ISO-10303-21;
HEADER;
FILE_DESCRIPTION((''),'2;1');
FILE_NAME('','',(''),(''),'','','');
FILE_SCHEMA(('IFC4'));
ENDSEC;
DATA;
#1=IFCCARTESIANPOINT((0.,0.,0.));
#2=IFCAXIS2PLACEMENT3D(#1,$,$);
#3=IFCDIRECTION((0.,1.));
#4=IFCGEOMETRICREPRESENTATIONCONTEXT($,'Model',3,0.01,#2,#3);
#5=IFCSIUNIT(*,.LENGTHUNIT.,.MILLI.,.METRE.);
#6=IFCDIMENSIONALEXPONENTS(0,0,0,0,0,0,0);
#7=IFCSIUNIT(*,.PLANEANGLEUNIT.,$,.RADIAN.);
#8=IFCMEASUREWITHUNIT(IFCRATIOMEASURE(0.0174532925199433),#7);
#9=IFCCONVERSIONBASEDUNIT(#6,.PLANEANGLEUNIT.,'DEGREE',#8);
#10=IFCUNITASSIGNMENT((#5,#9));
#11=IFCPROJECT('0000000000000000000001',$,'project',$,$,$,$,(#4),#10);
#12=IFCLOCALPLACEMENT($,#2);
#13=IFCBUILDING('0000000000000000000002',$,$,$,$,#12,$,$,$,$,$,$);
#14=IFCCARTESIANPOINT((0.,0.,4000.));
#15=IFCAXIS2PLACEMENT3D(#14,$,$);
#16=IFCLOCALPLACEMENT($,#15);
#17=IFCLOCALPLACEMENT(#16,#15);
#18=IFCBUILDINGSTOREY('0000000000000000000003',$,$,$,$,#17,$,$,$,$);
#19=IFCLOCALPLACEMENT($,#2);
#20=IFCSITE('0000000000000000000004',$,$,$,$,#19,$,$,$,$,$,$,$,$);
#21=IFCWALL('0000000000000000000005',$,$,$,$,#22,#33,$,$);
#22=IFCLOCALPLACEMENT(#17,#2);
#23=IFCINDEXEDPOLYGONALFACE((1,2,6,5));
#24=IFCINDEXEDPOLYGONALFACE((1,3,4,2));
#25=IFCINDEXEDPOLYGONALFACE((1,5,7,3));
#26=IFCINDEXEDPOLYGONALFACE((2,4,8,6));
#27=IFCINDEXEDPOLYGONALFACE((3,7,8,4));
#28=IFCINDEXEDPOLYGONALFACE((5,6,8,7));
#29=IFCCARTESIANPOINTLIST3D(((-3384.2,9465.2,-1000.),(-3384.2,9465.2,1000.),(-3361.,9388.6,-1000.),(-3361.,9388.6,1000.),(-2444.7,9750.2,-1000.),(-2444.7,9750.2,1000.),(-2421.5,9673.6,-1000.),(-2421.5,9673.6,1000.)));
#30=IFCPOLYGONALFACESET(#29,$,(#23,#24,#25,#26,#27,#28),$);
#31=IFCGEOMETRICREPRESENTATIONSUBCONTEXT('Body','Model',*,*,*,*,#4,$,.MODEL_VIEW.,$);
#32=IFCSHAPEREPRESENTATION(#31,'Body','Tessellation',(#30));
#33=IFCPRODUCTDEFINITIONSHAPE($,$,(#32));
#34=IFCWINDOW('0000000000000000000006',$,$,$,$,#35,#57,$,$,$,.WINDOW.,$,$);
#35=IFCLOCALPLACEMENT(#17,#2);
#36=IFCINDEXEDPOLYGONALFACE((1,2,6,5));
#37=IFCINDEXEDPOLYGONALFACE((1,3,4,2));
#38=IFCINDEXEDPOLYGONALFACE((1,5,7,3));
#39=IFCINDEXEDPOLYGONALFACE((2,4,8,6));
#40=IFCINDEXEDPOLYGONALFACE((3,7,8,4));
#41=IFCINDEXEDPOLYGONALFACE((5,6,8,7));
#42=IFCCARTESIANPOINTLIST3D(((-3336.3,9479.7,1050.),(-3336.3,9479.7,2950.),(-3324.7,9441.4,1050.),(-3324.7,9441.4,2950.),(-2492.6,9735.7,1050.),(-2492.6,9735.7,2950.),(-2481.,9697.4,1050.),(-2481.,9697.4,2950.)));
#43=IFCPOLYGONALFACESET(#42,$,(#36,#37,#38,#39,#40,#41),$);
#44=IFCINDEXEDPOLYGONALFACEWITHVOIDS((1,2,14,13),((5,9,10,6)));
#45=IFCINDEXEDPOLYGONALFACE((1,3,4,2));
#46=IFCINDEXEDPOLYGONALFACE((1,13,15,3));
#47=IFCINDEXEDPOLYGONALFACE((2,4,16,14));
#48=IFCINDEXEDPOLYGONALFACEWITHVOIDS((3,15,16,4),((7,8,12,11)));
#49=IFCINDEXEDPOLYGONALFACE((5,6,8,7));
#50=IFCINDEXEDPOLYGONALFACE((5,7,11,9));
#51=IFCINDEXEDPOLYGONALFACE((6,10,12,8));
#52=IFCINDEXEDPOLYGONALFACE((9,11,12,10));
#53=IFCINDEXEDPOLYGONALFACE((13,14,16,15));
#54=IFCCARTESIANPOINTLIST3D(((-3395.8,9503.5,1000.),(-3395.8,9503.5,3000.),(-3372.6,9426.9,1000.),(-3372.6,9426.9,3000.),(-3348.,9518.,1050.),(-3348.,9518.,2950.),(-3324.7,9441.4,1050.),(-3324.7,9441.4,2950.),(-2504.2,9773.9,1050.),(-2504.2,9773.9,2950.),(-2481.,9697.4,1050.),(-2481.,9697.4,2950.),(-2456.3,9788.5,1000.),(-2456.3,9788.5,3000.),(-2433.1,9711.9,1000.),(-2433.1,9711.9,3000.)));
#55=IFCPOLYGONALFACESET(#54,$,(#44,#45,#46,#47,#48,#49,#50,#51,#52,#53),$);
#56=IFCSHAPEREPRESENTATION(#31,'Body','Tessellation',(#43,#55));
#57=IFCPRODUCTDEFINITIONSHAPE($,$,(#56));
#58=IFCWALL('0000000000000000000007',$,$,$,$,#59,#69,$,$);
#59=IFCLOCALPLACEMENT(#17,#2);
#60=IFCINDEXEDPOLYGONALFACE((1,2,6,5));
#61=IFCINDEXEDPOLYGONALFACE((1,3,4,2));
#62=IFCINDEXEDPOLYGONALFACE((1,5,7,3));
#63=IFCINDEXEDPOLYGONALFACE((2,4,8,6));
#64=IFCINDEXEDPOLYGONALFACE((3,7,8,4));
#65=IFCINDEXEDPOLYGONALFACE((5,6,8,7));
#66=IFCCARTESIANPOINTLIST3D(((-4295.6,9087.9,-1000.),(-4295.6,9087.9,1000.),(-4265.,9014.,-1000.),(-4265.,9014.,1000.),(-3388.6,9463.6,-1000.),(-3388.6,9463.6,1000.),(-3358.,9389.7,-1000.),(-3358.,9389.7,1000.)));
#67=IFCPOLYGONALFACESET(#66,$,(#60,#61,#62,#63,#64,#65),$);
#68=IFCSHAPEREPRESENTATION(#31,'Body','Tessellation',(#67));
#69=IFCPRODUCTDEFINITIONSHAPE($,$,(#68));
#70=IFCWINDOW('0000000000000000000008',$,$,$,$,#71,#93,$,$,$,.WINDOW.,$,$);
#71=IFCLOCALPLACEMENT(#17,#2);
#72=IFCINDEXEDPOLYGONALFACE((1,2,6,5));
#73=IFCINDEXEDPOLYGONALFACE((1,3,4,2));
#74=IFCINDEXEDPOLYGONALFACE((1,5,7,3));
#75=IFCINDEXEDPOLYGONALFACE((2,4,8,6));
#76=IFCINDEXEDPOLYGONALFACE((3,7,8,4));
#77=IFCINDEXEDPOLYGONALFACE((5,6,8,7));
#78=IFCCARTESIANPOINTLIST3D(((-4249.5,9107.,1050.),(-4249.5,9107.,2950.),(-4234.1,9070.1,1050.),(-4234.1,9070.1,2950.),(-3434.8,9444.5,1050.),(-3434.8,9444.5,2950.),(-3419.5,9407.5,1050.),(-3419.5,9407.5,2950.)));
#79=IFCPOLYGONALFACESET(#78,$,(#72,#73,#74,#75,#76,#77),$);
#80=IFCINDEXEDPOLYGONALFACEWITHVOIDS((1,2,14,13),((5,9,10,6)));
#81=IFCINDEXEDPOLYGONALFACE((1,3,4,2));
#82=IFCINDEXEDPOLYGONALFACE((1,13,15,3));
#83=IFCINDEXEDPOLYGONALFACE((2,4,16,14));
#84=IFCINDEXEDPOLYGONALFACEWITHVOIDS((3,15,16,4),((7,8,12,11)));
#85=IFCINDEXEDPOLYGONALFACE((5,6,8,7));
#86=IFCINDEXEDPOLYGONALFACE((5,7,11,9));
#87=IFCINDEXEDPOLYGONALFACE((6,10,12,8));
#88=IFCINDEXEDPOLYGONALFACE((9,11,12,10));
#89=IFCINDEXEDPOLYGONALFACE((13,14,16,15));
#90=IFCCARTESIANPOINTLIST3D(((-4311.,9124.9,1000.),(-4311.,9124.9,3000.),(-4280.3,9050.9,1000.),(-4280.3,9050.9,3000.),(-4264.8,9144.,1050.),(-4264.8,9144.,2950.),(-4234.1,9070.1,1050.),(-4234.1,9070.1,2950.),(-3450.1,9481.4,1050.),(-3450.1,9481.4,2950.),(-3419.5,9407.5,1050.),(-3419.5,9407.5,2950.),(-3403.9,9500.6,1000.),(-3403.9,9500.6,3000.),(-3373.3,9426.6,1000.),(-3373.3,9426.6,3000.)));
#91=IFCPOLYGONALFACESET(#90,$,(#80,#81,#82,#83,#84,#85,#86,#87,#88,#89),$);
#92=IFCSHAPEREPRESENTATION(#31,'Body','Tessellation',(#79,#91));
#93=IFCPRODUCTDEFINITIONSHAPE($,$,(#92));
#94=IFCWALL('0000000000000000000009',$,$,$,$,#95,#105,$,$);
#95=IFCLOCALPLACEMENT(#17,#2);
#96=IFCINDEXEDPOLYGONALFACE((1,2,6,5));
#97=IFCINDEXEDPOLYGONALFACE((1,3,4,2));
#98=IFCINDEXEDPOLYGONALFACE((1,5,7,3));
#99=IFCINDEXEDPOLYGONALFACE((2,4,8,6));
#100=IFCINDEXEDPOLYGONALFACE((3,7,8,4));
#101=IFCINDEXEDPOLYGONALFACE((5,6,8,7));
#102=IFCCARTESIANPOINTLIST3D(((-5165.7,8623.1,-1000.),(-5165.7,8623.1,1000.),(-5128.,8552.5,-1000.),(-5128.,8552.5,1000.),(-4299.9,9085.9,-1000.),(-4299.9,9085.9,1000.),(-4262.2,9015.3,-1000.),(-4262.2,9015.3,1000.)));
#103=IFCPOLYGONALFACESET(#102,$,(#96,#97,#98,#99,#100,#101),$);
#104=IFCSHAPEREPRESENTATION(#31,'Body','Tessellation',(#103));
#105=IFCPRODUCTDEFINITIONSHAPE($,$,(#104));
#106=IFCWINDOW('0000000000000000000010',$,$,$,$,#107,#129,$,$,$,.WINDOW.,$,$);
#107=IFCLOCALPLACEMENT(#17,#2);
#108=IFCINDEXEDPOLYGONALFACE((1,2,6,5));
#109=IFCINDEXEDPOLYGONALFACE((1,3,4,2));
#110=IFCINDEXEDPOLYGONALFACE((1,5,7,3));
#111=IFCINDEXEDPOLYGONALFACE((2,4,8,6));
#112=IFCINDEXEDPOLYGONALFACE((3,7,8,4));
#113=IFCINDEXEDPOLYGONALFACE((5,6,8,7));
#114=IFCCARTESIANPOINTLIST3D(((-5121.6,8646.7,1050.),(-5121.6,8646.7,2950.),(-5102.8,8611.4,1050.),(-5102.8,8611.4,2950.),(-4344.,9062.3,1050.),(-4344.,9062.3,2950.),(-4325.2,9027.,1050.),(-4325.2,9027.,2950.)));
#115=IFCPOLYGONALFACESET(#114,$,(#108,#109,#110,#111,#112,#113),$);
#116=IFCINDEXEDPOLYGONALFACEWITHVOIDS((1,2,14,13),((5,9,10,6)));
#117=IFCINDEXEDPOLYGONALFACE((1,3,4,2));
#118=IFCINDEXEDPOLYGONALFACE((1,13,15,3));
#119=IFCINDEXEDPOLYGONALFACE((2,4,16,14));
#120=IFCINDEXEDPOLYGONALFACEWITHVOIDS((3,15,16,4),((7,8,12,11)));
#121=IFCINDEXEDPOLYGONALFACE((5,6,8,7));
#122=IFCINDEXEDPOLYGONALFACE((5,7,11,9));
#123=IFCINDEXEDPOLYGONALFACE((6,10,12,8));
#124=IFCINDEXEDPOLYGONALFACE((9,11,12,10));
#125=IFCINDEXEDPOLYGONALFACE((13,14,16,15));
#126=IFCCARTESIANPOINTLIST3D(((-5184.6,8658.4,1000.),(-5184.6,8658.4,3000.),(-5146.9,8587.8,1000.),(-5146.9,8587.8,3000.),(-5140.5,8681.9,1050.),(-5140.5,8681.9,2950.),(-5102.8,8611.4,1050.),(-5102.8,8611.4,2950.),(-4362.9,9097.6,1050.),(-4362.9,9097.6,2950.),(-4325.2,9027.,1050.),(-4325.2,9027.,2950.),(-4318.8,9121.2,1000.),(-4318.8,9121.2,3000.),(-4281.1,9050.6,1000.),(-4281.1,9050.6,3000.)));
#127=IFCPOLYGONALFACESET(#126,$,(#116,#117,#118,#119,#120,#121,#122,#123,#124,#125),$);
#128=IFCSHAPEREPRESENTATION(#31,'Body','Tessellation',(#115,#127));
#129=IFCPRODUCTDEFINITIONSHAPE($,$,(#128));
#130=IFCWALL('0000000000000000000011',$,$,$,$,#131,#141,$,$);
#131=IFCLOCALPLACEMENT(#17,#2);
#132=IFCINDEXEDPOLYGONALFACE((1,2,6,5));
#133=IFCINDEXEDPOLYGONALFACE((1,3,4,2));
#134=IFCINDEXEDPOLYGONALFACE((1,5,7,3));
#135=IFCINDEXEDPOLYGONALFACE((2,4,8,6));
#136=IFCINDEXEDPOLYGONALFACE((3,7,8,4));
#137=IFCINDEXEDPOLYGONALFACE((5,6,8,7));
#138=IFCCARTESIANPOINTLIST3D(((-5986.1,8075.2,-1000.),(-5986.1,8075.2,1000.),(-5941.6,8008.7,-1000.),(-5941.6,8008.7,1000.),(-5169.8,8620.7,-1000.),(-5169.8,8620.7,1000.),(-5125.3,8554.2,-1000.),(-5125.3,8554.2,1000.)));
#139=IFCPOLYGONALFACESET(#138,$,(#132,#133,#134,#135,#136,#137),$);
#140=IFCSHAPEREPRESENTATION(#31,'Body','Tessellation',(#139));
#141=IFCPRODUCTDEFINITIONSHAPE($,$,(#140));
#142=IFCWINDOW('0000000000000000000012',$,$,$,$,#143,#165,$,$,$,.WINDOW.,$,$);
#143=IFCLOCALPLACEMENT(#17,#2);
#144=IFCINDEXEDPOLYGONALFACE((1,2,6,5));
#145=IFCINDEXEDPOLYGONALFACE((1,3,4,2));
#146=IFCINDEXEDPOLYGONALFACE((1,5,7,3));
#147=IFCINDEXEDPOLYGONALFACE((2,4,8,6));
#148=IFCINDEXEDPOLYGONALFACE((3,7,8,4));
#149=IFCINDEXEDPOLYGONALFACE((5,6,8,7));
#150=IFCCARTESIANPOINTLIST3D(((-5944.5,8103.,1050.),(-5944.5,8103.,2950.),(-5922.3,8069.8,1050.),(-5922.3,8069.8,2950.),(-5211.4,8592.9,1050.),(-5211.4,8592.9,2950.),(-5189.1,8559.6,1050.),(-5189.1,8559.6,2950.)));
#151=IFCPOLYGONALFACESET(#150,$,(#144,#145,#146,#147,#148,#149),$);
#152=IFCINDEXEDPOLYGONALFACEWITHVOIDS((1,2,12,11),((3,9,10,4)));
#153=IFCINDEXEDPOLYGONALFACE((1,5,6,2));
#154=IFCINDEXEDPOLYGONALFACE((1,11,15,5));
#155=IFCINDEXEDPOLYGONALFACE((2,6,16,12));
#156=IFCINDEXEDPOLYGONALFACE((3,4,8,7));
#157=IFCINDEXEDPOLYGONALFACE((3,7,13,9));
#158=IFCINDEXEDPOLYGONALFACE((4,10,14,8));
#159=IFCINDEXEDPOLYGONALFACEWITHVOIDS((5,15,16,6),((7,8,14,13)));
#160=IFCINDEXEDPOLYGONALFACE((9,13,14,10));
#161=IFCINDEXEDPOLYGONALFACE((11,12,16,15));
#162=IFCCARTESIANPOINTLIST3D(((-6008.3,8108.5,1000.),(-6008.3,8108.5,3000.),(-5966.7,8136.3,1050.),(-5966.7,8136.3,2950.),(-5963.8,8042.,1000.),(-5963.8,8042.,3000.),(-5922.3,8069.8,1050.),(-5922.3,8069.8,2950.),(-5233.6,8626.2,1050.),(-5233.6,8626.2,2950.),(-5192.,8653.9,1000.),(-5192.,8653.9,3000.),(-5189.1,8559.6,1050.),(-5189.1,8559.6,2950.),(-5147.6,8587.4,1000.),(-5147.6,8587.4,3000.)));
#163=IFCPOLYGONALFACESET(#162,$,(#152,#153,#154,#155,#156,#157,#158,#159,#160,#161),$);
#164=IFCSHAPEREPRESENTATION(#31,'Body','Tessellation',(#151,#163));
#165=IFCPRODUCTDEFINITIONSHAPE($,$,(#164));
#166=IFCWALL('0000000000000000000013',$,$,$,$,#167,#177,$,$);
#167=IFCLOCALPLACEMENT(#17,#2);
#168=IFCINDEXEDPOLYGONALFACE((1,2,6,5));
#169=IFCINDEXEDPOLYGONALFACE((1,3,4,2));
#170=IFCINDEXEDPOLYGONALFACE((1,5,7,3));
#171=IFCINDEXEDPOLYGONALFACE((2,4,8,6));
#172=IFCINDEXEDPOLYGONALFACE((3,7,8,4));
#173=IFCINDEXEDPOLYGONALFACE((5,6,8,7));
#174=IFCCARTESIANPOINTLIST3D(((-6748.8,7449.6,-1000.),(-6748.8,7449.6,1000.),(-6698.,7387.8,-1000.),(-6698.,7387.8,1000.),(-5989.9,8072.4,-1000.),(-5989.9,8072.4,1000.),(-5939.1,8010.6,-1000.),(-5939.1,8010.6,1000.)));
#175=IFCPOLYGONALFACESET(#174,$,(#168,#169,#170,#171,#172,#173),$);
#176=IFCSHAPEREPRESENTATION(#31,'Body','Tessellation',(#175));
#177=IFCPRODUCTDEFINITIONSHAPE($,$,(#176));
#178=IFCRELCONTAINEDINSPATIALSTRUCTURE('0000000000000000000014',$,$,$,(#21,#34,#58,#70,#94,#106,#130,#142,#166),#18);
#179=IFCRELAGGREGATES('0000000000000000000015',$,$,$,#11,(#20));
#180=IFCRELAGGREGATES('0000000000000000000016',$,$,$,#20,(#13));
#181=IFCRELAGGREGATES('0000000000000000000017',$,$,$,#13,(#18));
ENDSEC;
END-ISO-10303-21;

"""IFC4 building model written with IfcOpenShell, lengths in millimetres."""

from ifc_helpers import new_model, entity, si_unit, converted_unit, direction, frame, origin, origin_2d, place, context, subcontext, project, spatial, rectangle, extrude, element, save


model = new_model("IFC4")

# Units and contexts
model_context = context("Model", 3, precision=0.01, world=origin(), true_north=direction((0.0, 1.0)))
body_context = subcontext(model_context, "Body", "Model", "MODEL_VIEW")
ifc_project = project(units=[si_unit("LENGTHUNIT", "METRE", prefix="MILLI"), converted_unit("PLANEANGLEUNIT", "DEGREE", entity("IfcRatioMeasure", 0.0174532925199433), si_unit("PLANEANGLEUNIT", "RADIAN"), dimensions=[0, 0, 0, 0, 0, 0, 0])], contexts=[model_context])

# Site, building, storey
site_placement = place(None, origin())
site = spatial("IfcSite", under=ifc_project, at=site_placement)
building_placement = place(None, origin())
building = spatial("IfcBuilding", under=site, at=building_placement)
placement = place(None, frame((0.0, 0.0, 4000.0)))
storey_placement = place(placement, frame((0.0, 0.0, 4000.0)))
storey = spatial("IfcBuildingStorey", under=building, at=storey_placement)

# Shared definitions
cartesian_point_1 = entity("IfcCartesianPoint", [-440.9, -950.0])
shared_polyline = entity("IfcPolyline", [cartesian_point_1, entity("IfcCartesianPoint", [-440.9, 950.0]), entity("IfcCartesianPoint", [-440.9, 950.0]), entity("IfcCartesianPoint", [440.9, 950.0]), entity("IfcCartesianPoint", [440.9, 950.0]), entity("IfcCartesianPoint", [440.9, -950.0]), entity("IfcCartesianPoint", [440.9, -950.0]), entity("IfcCartesianPoint", [-440.9, -950.0]), cartesian_point_1])

# Wall
wall_1_placement = place(storey_placement, frame((-2902.8, 9569.4, -1000.0), z_axis=(0.0, 0.0, 1.0), x_axis=(-9569.403228, -2902.847198, 0.0)))
element("IfcWall", 1, at=wall_1_placement, inside=storey, context=body_context, shape_type="SweptSolid", body=[
    extrude(rectangle(XDim=981.7, YDim=80.0, at=origin_2d()), origin(), (0.0, 0.0, 1.0), 2000.0),
])

# Window
window_1_placement = place(storey_placement, frame((-2902.8, 9569.4, 2000.0), z_axis=(0.0, 0.0, 1.0), x_axis=(-9569.403228, -2902.847198, 0.0)))
cartesian_point_2 = entity("IfcCartesianPoint", [-490.9, -1000.0])
element("IfcWindow", 2, at=window_1_placement, inside=storey, PredefinedType="WINDOW", context=body_context, shape_type="SweptSolid", body=[
    entity("IfcExtrudedAreaSolid", entity("IfcArbitraryClosedProfileDef", "AREA", None, shared_polyline), entity("IfcAxis2Placement3D", entity("IfcCartesianPoint", [0.0, 0.0, 0.0]), entity("IfcDirection", [0.0, -1.0, 0.0]), entity("IfcDirection", [1.0, 0.0, 0.0])), entity("IfcDirection", [0.0, 0.0, 1.0]), 40.0),
    entity("IfcExtrudedAreaSolid", entity("IfcArbitraryProfileDefWithVoids", "AREA", None, entity("IfcPolyline", [cartesian_point_2, entity("IfcCartesianPoint", [-490.9, 1000.0]), entity("IfcCartesianPoint", [-490.9, 1000.0]), entity("IfcCartesianPoint", [490.9, 1000.0]), entity("IfcCartesianPoint", [490.9, 1000.0]), entity("IfcCartesianPoint", [490.9, -1000.0]), entity("IfcCartesianPoint", [490.9, -1000.0]), entity("IfcCartesianPoint", [-490.9, -1000.0]), cartesian_point_2]), [shared_polyline]), entity("IfcAxis2Placement3D", entity("IfcCartesianPoint", [0.0, 0.0, 0.0]), entity("IfcDirection", [0.0, -1.0, 0.0]), entity("IfcDirection", [1.0, 0.0, 0.0])), entity("IfcDirection", [0.0, 0.0, 1.0]), 80.0),
])

# Wall
wall_2_placement = place(storey_placement, frame((-3826.8, 9238.8, -1000.0), z_axis=(0.0, 0.0, 1.0), x_axis=(-9238.795458, -3826.834002, 0.0)))
element("IfcWall", 3, at=wall_2_placement, inside=storey, context=body_context, shape_type="SweptSolid", body=[
    extrude(rectangle(XDim=981.7, YDim=80.0, at=origin_2d()), origin(), (0.0, 0.0, 1.0), 2000.0),
])

# Window
window_2_placement = place(storey_placement, frame((-3826.8, 9238.8, 2000.0), z_axis=(0.0, 0.0, 1.0), x_axis=(-9238.795458, -3826.834002, 0.0)))
cartesian_point_3 = entity("IfcCartesianPoint", [-490.9, -1000.0])
element("IfcWindow", 4, at=window_2_placement, inside=storey, PredefinedType="WINDOW", context=body_context, shape_type="SweptSolid", body=[
    entity("IfcExtrudedAreaSolid", entity("IfcArbitraryClosedProfileDef", "AREA", None, shared_polyline), entity("IfcAxis2Placement3D", entity("IfcCartesianPoint", [0.0, 0.0, 0.0]), entity("IfcDirection", [0.0, -1.0, 0.0]), entity("IfcDirection", [1.0, 0.0, 0.0])), entity("IfcDirection", [0.0, 0.0, 1.0]), 40.0),
    entity("IfcExtrudedAreaSolid", entity("IfcArbitraryProfileDefWithVoids", "AREA", None, entity("IfcPolyline", [cartesian_point_3, entity("IfcCartesianPoint", [-490.9, 1000.0]), entity("IfcCartesianPoint", [-490.9, 1000.0]), entity("IfcCartesianPoint", [490.9, 1000.0]), entity("IfcCartesianPoint", [490.9, 1000.0]), entity("IfcCartesianPoint", [490.9, -1000.0]), entity("IfcCartesianPoint", [490.9, -1000.0]), entity("IfcCartesianPoint", [-490.9, -1000.0]), cartesian_point_3]), [shared_polyline]), entity("IfcAxis2Placement3D", entity("IfcCartesianPoint", [0.0, 0.0, 0.0]), entity("IfcDirection", [0.0, -1.0, 0.0]), entity("IfcDirection", [1.0, 0.0, 0.0])), entity("IfcDirection", [0.0, 0.0, 1.0]), 80.0),
])

# Wall
wall_3_placement = place(storey_placement, frame((-4714.0, 8819.2, -1000.0), z_axis=(0.0, 0.0, 1.0), x_axis=(-8819.213181, -4713.966363, 0.0)))
element("IfcWall", 5, at=wall_3_placement, inside=storey, context=body_context, shape_type="SweptSolid", body=[
    extrude(rectangle(XDim=981.7, YDim=80.0, at=origin_2d()), origin(), (0.0, 0.0, 1.0), 2000.0),
])

# Window
window_3_placement = place(storey_placement, frame((-4714.0, 8819.2, 2000.0), z_axis=(0.0, 0.0, 1.0), x_axis=(-8819.213181, -4713.966363, 0.0)))
cartesian_point_4 = entity("IfcCartesianPoint", [-490.9, -1000.0])
element("IfcWindow", 6, at=window_3_placement, inside=storey, PredefinedType="WINDOW", context=body_context, shape_type="SweptSolid", body=[
    entity("IfcExtrudedAreaSolid", entity("IfcArbitraryClosedProfileDef", "AREA", None, shared_polyline), entity("IfcAxis2Placement3D", entity("IfcCartesianPoint", [0.0, 0.0, 0.0]), entity("IfcDirection", [0.0, -1.0, 0.0]), entity("IfcDirection", [1.0, 0.0, 0.0])), entity("IfcDirection", [0.0, 0.0, 1.0]), 40.0),
    entity("IfcExtrudedAreaSolid", entity("IfcArbitraryProfileDefWithVoids", "AREA", None, entity("IfcPolyline", [cartesian_point_4, entity("IfcCartesianPoint", [-490.9, 1000.0]), entity("IfcCartesianPoint", [-490.9, 1000.0]), entity("IfcCartesianPoint", [490.9, 1000.0]), entity("IfcCartesianPoint", [490.9, 1000.0]), entity("IfcCartesianPoint", [490.9, -1000.0]), entity("IfcCartesianPoint", [490.9, -1000.0]), entity("IfcCartesianPoint", [-490.9, -1000.0]), cartesian_point_4]), [shared_polyline]), entity("IfcAxis2Placement3D", entity("IfcCartesianPoint", [0.0, 0.0, 0.0]), entity("IfcDirection", [0.0, -1.0, 0.0]), entity("IfcDirection", [1.0, 0.0, 0.0])), entity("IfcDirection", [0.0, 0.0, 1.0]), 80.0),
])

# Wall
wall_4_placement = place(storey_placement, frame((-5555.7, 8314.7, -1000.0), z_axis=(0.0, 0.0, 1.0), x_axis=(-8314.696534, -5555.701715, 0.0)))
element("IfcWall", 7, at=wall_4_placement, inside=storey, context=body_context, shape_type="SweptSolid", body=[
    extrude(rectangle(XDim=981.7, YDim=80.0, at=origin_2d()), origin(), (0.0, 0.0, 1.0), 2000.0),
])

# Window
window_4_placement = place(storey_placement, frame((-5555.7, 8314.7, 2000.0), z_axis=(0.0, 0.0, 1.0), x_axis=(-8314.696534, -5555.701715, 0.0)))
cartesian_point_5 = entity("IfcCartesianPoint", [-490.9, -1000.0])
element("IfcWindow", 8, at=window_4_placement, inside=storey, PredefinedType="WINDOW", context=body_context, shape_type="SweptSolid", body=[
    entity("IfcExtrudedAreaSolid", entity("IfcArbitraryClosedProfileDef", "AREA", None, shared_polyline), entity("IfcAxis2Placement3D", entity("IfcCartesianPoint", [0.0, 0.0, 0.0]), entity("IfcDirection", [0.0, -1.0, 0.0]), entity("IfcDirection", [1.0, 0.0, 0.0])), entity("IfcDirection", [0.0, 0.0, 1.0]), 40.0),
    entity("IfcExtrudedAreaSolid", entity("IfcArbitraryProfileDefWithVoids", "AREA", None, entity("IfcPolyline", [cartesian_point_5, entity("IfcCartesianPoint", [-490.9, 1000.0]), entity("IfcCartesianPoint", [-490.9, 1000.0]), entity("IfcCartesianPoint", [490.9, 1000.0]), entity("IfcCartesianPoint", [490.9, 1000.0]), entity("IfcCartesianPoint", [490.9, -1000.0]), entity("IfcCartesianPoint", [490.9, -1000.0]), entity("IfcCartesianPoint", [-490.9, -1000.0]), cartesian_point_5]), [shared_polyline]), entity("IfcAxis2Placement3D", entity("IfcCartesianPoint", [0.0, 0.0, 0.0]), entity("IfcDirection", [0.0, -1.0, 0.0]), entity("IfcDirection", [1.0, 0.0, 0.0])), entity("IfcDirection", [0.0, 0.0, 1.0]), 80.0),
])

# Wall
wall_5_placement = place(storey_placement, frame((-6343.9, 7730.1, -1000.0), z_axis=(0.0, 0.0, 1.0), x_axis=(-7730.104749, -6343.932579, 0.0)))
element("IfcWall", 9, at=wall_5_placement, inside=storey, context=body_context, shape_type="SweptSolid", body=[
    extrude(rectangle(XDim=981.7, YDim=80.0, at=origin_2d()), origin(), (0.0, 0.0, 1.0), 2000.0),
])

save(model, "model.ifc")
